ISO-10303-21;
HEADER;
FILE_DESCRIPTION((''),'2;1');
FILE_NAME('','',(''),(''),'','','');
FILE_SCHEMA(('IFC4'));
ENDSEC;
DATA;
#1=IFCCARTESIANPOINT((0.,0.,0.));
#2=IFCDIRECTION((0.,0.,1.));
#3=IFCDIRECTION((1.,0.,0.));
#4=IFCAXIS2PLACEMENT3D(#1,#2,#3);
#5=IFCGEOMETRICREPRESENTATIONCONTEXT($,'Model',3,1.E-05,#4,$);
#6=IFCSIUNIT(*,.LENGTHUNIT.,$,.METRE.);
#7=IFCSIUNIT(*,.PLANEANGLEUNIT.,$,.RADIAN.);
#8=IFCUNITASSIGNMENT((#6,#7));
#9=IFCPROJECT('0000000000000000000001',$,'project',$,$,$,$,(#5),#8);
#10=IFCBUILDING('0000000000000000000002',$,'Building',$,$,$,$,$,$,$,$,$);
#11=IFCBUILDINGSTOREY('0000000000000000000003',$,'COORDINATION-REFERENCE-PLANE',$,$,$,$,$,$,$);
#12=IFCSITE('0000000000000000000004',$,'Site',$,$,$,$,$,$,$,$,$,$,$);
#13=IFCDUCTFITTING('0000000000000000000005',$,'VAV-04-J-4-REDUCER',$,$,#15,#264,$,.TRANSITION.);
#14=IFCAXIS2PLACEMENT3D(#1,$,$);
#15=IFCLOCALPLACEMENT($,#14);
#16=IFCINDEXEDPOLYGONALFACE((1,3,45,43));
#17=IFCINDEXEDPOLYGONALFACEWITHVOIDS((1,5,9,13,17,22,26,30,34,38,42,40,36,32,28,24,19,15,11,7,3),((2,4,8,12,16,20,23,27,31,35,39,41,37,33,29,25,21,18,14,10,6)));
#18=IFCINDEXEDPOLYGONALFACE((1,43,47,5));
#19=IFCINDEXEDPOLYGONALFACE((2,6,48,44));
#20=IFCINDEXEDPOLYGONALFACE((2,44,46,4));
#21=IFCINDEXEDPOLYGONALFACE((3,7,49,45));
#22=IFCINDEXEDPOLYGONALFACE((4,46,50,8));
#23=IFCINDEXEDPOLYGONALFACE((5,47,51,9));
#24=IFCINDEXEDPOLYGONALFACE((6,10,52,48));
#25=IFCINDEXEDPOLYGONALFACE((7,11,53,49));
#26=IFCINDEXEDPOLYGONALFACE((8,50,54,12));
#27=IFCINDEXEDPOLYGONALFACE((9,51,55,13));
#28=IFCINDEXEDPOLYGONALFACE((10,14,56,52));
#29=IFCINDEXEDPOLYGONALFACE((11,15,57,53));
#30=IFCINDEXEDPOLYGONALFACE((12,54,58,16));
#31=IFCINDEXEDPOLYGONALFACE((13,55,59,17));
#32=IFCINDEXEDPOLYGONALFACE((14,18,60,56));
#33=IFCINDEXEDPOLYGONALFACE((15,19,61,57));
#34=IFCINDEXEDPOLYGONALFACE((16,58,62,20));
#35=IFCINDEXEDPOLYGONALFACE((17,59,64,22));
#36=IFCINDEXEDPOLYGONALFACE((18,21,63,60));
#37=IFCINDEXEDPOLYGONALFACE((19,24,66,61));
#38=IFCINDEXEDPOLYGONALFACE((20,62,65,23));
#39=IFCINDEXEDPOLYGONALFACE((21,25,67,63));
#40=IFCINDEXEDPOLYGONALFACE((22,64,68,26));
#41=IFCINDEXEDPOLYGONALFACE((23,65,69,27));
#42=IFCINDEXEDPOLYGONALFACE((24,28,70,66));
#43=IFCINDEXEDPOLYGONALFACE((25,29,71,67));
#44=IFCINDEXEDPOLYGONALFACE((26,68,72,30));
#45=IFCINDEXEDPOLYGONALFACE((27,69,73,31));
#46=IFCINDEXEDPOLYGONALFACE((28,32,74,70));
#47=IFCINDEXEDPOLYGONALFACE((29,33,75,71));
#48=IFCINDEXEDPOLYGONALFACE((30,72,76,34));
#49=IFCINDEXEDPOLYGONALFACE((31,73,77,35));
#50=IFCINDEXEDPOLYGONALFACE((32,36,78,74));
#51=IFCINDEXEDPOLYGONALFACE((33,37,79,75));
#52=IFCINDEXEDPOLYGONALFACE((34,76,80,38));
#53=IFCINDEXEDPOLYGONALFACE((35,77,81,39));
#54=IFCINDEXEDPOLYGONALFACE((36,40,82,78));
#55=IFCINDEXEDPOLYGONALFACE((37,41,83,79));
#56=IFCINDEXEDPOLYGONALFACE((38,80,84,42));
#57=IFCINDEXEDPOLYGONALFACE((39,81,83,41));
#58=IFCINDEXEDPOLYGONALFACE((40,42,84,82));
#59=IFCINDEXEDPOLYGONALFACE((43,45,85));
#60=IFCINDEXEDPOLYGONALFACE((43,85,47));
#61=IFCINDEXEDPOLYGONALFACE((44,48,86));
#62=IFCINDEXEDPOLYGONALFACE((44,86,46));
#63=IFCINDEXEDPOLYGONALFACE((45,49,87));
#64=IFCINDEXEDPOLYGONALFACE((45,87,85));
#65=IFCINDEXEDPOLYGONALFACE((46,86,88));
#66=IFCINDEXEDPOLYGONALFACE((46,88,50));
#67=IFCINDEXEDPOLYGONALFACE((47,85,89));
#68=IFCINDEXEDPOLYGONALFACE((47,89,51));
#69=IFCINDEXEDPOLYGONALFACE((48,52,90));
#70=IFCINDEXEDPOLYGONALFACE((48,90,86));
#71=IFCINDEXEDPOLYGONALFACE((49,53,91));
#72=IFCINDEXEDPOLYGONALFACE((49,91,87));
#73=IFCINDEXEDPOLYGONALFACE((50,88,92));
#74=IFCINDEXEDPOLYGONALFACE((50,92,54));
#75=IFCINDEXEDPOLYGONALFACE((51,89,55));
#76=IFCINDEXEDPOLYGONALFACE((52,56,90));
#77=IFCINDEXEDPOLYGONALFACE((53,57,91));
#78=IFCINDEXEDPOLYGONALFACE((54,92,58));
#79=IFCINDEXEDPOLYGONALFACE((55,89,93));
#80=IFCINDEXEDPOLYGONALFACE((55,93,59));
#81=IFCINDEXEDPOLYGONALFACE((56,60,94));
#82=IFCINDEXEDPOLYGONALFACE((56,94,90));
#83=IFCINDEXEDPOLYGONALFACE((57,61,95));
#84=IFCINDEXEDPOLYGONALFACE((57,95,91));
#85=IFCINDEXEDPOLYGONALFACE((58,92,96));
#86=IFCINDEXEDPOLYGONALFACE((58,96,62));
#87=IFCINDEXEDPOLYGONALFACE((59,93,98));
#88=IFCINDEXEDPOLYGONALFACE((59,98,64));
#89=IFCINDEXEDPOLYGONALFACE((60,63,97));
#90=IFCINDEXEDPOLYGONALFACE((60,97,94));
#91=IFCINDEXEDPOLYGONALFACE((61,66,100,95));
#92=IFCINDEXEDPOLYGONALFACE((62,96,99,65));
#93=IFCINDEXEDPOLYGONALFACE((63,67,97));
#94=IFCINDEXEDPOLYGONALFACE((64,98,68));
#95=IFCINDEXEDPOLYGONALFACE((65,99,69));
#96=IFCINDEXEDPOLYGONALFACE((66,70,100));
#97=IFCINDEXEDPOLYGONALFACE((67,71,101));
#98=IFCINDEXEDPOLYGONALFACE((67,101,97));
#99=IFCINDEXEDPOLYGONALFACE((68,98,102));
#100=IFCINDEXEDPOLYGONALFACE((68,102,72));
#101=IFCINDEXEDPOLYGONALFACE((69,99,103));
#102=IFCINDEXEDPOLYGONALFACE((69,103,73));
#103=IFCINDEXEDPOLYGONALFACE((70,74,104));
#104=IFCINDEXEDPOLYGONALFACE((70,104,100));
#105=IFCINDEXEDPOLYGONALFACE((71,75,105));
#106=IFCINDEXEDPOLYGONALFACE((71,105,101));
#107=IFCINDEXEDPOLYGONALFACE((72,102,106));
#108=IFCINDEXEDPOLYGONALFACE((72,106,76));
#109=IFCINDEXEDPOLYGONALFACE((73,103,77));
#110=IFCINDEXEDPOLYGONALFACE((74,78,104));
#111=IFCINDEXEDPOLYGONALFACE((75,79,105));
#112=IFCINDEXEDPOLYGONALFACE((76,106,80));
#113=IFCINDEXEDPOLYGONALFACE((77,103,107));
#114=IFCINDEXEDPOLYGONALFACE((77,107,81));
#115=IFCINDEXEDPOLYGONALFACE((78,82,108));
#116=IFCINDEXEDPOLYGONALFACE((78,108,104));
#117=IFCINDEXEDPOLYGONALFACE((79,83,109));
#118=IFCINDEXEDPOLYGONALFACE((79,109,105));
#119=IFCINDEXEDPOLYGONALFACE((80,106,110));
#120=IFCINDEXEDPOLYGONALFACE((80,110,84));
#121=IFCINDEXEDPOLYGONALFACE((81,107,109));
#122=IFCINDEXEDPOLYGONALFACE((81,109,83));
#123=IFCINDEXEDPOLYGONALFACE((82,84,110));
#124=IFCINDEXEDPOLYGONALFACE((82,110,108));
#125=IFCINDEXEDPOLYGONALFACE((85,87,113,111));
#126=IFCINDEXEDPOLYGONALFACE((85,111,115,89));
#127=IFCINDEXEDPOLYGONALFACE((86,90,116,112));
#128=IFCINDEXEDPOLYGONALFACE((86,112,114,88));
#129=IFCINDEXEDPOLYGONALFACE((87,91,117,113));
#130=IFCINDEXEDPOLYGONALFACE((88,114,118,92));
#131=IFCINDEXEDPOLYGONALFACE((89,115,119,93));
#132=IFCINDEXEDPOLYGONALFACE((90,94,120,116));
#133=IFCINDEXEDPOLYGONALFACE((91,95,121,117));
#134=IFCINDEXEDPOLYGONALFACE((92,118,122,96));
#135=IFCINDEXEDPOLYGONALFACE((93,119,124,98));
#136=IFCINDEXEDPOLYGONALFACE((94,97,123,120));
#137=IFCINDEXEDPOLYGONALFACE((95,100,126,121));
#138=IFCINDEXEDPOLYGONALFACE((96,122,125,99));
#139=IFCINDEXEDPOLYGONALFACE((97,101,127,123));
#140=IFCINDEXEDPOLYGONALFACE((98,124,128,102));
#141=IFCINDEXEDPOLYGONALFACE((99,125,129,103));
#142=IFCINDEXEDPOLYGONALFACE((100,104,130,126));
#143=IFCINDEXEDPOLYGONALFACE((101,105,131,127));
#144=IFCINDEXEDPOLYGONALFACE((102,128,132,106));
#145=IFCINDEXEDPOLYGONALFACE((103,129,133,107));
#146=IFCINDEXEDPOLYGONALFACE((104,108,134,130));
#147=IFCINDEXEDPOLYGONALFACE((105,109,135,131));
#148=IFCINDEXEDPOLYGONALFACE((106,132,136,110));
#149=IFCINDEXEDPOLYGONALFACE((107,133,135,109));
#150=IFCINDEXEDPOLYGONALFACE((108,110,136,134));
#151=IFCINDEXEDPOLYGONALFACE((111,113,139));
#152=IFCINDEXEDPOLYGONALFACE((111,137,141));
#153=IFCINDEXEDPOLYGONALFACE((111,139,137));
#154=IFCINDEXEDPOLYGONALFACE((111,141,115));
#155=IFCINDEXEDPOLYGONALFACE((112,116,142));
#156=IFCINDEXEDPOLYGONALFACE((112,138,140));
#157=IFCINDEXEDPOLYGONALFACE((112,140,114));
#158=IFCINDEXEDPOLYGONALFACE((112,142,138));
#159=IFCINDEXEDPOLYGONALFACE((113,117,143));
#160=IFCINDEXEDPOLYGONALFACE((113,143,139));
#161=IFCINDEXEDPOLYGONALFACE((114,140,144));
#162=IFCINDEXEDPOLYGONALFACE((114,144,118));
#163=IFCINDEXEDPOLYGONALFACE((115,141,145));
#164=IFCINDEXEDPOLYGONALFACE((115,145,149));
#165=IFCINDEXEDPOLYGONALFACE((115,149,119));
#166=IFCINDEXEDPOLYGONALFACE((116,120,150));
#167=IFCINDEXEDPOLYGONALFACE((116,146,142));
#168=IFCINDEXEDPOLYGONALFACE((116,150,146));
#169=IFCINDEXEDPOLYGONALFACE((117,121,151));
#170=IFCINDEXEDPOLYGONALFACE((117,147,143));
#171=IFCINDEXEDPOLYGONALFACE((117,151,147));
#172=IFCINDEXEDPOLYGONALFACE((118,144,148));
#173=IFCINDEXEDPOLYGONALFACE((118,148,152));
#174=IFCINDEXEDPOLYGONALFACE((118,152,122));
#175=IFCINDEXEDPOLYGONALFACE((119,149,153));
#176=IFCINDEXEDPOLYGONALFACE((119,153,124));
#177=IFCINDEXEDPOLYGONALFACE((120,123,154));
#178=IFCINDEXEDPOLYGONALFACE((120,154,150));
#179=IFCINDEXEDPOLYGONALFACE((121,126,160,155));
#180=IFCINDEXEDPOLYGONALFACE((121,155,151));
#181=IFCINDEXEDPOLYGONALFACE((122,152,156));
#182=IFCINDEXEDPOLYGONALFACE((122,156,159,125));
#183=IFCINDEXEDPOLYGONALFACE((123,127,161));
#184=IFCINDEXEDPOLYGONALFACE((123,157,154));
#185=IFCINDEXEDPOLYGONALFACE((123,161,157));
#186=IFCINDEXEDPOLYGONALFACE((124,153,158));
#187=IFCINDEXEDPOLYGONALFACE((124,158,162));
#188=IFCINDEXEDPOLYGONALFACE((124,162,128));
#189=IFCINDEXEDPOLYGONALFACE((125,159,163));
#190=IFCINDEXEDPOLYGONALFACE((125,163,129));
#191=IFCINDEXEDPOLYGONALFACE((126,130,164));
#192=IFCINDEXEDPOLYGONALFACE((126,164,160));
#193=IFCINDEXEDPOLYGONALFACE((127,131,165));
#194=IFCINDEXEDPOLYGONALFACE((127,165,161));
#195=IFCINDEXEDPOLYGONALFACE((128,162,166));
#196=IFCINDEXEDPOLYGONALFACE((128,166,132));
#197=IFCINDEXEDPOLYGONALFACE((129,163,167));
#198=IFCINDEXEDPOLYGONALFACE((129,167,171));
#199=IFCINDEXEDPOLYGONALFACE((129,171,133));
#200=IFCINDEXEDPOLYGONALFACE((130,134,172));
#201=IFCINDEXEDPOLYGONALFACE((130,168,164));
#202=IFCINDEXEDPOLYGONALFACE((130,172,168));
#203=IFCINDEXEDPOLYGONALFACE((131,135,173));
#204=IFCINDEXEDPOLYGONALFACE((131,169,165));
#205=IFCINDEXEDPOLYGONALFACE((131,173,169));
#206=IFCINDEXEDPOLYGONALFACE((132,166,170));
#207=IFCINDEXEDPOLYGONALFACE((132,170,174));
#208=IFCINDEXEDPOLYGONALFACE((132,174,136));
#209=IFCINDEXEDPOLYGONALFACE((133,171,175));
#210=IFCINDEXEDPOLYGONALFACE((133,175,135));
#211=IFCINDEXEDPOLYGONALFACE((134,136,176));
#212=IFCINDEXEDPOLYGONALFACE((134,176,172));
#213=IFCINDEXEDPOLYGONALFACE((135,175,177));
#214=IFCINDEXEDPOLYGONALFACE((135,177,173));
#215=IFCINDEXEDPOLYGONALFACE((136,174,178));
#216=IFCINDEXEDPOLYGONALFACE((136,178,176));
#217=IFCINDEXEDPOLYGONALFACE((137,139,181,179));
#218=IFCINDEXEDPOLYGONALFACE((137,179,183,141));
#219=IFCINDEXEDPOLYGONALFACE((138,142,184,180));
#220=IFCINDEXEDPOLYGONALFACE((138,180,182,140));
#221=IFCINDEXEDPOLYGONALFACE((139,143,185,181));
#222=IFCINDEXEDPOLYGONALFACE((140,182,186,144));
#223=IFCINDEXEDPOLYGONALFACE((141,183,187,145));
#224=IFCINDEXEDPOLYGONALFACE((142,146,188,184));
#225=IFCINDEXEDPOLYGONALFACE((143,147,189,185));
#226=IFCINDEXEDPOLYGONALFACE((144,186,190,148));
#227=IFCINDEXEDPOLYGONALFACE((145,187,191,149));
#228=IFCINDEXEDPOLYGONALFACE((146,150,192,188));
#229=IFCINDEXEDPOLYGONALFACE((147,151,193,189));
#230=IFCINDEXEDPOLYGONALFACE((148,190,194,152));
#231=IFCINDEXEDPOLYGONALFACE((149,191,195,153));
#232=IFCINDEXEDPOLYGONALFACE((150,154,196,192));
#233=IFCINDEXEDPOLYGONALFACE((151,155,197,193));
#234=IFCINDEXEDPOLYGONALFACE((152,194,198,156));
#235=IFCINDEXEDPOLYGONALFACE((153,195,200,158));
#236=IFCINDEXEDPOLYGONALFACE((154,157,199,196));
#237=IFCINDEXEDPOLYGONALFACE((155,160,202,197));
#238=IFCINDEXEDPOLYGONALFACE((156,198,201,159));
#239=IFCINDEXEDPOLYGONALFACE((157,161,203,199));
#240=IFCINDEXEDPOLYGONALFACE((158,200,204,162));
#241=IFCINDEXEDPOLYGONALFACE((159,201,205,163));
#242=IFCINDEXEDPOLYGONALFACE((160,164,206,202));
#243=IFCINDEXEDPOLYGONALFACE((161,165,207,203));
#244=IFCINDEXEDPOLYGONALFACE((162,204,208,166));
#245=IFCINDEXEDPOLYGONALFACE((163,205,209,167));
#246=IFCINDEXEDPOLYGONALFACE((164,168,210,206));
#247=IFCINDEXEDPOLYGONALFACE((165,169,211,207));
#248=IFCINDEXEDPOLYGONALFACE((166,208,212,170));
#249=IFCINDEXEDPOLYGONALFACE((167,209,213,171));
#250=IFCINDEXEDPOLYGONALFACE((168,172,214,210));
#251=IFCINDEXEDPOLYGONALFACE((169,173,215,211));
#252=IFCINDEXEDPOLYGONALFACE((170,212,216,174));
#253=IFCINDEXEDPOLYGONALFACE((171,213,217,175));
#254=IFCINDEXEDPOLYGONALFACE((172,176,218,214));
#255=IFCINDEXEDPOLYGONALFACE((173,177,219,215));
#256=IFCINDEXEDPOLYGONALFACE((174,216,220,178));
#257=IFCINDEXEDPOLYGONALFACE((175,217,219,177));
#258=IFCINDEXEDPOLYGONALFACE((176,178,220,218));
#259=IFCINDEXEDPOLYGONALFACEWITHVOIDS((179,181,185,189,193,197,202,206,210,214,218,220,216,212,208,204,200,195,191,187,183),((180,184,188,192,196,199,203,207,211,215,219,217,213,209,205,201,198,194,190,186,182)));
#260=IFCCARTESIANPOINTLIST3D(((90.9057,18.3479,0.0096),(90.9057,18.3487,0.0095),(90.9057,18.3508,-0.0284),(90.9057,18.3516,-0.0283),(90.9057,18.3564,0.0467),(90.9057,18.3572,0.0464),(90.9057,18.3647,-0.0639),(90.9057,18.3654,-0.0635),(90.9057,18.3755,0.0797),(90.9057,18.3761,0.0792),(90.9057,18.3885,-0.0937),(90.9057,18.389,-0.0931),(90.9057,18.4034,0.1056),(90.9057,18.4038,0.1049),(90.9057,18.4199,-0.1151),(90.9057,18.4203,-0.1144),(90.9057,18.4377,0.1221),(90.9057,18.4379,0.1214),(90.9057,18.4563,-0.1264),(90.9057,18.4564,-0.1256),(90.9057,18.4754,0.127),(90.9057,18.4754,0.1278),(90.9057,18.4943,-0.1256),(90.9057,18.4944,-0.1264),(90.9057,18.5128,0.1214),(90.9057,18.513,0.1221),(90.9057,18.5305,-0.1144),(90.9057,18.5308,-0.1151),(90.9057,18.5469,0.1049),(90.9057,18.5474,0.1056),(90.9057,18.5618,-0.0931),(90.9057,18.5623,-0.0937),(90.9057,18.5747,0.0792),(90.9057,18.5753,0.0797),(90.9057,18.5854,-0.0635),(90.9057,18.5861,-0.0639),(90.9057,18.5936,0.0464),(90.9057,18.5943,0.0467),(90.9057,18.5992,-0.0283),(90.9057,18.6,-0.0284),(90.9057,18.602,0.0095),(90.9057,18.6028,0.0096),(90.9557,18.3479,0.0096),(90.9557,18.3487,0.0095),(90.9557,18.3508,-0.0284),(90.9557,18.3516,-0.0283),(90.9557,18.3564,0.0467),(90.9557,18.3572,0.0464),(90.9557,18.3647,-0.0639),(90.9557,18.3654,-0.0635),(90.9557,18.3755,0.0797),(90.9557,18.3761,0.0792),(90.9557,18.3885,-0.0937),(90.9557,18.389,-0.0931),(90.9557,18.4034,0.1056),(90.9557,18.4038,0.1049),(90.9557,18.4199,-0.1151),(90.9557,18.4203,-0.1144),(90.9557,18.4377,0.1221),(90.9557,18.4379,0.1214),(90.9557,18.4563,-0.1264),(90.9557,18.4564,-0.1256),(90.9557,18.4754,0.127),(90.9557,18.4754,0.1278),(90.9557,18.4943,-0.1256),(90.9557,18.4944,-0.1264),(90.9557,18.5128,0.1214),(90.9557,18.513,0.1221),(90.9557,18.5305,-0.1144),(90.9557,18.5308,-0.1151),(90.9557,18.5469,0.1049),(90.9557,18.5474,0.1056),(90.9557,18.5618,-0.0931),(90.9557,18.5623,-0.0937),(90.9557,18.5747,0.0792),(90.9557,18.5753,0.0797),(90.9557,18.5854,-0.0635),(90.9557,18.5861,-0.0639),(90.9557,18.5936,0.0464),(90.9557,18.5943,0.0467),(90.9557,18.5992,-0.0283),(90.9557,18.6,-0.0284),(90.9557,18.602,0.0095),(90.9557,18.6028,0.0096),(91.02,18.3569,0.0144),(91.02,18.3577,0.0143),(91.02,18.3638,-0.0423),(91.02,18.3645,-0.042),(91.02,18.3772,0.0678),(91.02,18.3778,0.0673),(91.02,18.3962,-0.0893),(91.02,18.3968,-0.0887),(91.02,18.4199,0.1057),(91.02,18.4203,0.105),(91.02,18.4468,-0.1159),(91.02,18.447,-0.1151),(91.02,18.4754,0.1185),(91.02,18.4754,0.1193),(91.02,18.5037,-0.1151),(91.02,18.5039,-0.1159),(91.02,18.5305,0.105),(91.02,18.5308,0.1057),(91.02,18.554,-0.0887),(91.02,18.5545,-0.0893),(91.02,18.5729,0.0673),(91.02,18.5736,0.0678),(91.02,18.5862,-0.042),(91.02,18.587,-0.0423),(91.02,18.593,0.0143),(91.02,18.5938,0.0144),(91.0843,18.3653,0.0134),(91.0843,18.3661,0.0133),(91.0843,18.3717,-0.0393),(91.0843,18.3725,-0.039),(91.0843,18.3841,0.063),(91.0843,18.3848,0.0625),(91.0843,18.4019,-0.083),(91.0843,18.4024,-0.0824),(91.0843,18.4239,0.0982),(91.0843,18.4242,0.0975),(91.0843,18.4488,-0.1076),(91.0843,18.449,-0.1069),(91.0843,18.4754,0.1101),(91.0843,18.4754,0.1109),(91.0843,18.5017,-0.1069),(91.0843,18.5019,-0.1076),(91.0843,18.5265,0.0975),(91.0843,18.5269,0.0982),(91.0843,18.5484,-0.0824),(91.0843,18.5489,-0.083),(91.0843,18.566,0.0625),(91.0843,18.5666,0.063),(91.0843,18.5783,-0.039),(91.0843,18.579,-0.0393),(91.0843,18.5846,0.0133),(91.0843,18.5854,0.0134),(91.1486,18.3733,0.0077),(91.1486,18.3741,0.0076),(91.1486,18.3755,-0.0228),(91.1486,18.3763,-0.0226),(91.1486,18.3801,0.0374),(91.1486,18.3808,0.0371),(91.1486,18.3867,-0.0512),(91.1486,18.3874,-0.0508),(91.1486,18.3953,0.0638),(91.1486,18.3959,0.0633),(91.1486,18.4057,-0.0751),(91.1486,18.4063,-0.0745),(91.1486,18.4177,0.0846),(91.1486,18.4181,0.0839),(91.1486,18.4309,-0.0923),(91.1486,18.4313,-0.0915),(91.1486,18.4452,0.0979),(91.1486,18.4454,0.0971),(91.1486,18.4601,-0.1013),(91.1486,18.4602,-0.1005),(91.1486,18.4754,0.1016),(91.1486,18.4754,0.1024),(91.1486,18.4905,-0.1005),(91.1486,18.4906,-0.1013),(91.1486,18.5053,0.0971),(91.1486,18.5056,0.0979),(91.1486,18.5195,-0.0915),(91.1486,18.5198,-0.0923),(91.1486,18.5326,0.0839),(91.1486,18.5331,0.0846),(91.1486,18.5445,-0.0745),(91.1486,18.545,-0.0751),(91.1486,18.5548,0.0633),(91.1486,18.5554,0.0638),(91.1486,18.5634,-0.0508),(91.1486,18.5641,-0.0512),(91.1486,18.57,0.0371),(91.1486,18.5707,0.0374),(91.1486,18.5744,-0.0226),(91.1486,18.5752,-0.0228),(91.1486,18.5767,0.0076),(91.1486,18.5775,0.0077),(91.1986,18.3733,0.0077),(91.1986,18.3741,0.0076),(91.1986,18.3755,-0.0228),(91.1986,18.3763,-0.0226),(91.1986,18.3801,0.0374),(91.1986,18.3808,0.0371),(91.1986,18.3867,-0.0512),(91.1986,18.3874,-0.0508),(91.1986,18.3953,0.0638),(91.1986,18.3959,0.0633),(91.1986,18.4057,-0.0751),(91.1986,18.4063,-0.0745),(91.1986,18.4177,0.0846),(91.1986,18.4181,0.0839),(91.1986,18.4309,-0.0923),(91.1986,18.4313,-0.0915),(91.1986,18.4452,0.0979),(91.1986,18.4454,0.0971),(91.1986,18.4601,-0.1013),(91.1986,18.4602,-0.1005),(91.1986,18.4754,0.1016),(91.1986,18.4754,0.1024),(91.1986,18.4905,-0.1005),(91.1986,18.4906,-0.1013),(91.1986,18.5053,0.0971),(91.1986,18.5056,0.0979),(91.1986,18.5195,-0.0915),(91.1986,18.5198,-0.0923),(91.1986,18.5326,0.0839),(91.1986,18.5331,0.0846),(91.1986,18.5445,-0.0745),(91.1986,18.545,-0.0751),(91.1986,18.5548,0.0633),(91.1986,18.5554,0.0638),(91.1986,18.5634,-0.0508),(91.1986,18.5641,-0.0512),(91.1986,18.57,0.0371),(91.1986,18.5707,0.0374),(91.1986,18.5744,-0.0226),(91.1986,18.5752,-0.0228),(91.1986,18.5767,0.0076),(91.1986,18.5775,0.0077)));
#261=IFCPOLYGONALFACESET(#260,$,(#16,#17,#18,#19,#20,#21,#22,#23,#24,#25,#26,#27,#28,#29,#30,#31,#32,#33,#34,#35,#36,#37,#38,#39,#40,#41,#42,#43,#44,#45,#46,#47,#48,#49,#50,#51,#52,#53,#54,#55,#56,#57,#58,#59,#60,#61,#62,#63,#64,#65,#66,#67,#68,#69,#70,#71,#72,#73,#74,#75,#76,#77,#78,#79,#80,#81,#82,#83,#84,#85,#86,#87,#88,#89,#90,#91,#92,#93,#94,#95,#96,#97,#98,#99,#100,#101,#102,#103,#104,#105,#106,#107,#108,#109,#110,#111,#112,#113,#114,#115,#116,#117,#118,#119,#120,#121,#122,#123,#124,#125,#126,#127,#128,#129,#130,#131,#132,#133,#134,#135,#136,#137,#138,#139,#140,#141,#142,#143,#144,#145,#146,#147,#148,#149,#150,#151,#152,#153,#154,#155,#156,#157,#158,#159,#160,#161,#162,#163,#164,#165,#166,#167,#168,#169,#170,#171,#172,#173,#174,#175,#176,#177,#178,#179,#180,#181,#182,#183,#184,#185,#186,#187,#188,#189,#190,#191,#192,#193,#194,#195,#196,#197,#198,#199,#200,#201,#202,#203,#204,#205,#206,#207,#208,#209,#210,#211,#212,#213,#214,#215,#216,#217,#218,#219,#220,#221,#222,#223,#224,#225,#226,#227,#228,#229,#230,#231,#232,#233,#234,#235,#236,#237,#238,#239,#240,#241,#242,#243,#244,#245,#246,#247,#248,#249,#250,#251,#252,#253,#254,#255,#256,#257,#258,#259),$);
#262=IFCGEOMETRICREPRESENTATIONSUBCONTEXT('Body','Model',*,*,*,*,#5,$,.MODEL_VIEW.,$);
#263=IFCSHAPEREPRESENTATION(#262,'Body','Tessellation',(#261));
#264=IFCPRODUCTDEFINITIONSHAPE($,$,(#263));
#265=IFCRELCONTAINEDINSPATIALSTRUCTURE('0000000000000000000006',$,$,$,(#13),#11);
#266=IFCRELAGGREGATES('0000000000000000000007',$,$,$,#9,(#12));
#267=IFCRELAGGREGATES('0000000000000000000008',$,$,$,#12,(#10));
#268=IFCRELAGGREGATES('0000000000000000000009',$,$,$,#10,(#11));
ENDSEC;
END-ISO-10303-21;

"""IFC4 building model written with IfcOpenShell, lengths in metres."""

from ifc_helpers import new_model, entity, si_unit, frame, origin_with_axes, place, context, subcontext, project, spatial, element, save


model = new_model("IFC4")

# Units and contexts
model_context = context("Model", 3, precision=1e-05, world=origin_with_axes())
body_context_1 = subcontext(model_context, "Body", "Model", "MODEL_VIEW")
ifc_project = project(units=[si_unit("LENGTHUNIT", "METRE"), si_unit("PLANEANGLEUNIT", "RADIAN")], contexts=[model_context])

# Site, building, storey
site = spatial("IfcSite", under=ifc_project, Name="Site")
building = spatial("IfcBuilding", under=site, Name="Building")
storey = spatial("IfcBuildingStorey", under=building, Name="COORDINATION-REFERENCE-PLANE")

# Duct fitting
for number, where, z_axis, x_axis, name in (
    (1, (90.9057, 18.4754, 0.0), (0.0, 1.0, 0.0), (0.0, 0.0, 1.0), "VAV-04-J-4-REDUCER"),
):
    element("IfcDuctFitting", number, at=place(None, frame(where, z_axis=z_axis, x_axis=x_axis)), inside=storey, Name=name, PredefinedType="TRANSITION", context=body_context_1, shape_type="SweptSolid", body=[
        entity("IfcRevolvedAreaSolid", entity("IfcArbitraryClosedProfileDef", "AREA", None, entity("IfcPolyline", [entity("IfcCartesianPoint", [0.1278, 0.0]), entity("IfcCartesianPoint", [0.1278, 0.05]), entity("IfcCartesianPoint", [0.1024, 0.2429]), entity("IfcCartesianPoint", [0.1024, 0.2929]), entity("IfcCartesianPoint", [0.1016, 0.2929]), entity("IfcCartesianPoint", [0.1016, 0.2429]), entity("IfcCartesianPoint", [0.127, 0.05]), entity("IfcCartesianPoint", [0.127, 0.0]), entity("IfcCartesianPoint", [0.1278, 0.0])])), entity("IfcAxis2Placement3D", entity("IfcCartesianPoint", [0.0, 0.0, 0.0])), entity("IfcAxis1Placement", entity("IfcCartesianPoint", [0.0, 0.0, 0.0]), entity("IfcDirection", [0.0, 1.0, 0.0])), 6.283185),
    ])

save(model, "model.ifc")
